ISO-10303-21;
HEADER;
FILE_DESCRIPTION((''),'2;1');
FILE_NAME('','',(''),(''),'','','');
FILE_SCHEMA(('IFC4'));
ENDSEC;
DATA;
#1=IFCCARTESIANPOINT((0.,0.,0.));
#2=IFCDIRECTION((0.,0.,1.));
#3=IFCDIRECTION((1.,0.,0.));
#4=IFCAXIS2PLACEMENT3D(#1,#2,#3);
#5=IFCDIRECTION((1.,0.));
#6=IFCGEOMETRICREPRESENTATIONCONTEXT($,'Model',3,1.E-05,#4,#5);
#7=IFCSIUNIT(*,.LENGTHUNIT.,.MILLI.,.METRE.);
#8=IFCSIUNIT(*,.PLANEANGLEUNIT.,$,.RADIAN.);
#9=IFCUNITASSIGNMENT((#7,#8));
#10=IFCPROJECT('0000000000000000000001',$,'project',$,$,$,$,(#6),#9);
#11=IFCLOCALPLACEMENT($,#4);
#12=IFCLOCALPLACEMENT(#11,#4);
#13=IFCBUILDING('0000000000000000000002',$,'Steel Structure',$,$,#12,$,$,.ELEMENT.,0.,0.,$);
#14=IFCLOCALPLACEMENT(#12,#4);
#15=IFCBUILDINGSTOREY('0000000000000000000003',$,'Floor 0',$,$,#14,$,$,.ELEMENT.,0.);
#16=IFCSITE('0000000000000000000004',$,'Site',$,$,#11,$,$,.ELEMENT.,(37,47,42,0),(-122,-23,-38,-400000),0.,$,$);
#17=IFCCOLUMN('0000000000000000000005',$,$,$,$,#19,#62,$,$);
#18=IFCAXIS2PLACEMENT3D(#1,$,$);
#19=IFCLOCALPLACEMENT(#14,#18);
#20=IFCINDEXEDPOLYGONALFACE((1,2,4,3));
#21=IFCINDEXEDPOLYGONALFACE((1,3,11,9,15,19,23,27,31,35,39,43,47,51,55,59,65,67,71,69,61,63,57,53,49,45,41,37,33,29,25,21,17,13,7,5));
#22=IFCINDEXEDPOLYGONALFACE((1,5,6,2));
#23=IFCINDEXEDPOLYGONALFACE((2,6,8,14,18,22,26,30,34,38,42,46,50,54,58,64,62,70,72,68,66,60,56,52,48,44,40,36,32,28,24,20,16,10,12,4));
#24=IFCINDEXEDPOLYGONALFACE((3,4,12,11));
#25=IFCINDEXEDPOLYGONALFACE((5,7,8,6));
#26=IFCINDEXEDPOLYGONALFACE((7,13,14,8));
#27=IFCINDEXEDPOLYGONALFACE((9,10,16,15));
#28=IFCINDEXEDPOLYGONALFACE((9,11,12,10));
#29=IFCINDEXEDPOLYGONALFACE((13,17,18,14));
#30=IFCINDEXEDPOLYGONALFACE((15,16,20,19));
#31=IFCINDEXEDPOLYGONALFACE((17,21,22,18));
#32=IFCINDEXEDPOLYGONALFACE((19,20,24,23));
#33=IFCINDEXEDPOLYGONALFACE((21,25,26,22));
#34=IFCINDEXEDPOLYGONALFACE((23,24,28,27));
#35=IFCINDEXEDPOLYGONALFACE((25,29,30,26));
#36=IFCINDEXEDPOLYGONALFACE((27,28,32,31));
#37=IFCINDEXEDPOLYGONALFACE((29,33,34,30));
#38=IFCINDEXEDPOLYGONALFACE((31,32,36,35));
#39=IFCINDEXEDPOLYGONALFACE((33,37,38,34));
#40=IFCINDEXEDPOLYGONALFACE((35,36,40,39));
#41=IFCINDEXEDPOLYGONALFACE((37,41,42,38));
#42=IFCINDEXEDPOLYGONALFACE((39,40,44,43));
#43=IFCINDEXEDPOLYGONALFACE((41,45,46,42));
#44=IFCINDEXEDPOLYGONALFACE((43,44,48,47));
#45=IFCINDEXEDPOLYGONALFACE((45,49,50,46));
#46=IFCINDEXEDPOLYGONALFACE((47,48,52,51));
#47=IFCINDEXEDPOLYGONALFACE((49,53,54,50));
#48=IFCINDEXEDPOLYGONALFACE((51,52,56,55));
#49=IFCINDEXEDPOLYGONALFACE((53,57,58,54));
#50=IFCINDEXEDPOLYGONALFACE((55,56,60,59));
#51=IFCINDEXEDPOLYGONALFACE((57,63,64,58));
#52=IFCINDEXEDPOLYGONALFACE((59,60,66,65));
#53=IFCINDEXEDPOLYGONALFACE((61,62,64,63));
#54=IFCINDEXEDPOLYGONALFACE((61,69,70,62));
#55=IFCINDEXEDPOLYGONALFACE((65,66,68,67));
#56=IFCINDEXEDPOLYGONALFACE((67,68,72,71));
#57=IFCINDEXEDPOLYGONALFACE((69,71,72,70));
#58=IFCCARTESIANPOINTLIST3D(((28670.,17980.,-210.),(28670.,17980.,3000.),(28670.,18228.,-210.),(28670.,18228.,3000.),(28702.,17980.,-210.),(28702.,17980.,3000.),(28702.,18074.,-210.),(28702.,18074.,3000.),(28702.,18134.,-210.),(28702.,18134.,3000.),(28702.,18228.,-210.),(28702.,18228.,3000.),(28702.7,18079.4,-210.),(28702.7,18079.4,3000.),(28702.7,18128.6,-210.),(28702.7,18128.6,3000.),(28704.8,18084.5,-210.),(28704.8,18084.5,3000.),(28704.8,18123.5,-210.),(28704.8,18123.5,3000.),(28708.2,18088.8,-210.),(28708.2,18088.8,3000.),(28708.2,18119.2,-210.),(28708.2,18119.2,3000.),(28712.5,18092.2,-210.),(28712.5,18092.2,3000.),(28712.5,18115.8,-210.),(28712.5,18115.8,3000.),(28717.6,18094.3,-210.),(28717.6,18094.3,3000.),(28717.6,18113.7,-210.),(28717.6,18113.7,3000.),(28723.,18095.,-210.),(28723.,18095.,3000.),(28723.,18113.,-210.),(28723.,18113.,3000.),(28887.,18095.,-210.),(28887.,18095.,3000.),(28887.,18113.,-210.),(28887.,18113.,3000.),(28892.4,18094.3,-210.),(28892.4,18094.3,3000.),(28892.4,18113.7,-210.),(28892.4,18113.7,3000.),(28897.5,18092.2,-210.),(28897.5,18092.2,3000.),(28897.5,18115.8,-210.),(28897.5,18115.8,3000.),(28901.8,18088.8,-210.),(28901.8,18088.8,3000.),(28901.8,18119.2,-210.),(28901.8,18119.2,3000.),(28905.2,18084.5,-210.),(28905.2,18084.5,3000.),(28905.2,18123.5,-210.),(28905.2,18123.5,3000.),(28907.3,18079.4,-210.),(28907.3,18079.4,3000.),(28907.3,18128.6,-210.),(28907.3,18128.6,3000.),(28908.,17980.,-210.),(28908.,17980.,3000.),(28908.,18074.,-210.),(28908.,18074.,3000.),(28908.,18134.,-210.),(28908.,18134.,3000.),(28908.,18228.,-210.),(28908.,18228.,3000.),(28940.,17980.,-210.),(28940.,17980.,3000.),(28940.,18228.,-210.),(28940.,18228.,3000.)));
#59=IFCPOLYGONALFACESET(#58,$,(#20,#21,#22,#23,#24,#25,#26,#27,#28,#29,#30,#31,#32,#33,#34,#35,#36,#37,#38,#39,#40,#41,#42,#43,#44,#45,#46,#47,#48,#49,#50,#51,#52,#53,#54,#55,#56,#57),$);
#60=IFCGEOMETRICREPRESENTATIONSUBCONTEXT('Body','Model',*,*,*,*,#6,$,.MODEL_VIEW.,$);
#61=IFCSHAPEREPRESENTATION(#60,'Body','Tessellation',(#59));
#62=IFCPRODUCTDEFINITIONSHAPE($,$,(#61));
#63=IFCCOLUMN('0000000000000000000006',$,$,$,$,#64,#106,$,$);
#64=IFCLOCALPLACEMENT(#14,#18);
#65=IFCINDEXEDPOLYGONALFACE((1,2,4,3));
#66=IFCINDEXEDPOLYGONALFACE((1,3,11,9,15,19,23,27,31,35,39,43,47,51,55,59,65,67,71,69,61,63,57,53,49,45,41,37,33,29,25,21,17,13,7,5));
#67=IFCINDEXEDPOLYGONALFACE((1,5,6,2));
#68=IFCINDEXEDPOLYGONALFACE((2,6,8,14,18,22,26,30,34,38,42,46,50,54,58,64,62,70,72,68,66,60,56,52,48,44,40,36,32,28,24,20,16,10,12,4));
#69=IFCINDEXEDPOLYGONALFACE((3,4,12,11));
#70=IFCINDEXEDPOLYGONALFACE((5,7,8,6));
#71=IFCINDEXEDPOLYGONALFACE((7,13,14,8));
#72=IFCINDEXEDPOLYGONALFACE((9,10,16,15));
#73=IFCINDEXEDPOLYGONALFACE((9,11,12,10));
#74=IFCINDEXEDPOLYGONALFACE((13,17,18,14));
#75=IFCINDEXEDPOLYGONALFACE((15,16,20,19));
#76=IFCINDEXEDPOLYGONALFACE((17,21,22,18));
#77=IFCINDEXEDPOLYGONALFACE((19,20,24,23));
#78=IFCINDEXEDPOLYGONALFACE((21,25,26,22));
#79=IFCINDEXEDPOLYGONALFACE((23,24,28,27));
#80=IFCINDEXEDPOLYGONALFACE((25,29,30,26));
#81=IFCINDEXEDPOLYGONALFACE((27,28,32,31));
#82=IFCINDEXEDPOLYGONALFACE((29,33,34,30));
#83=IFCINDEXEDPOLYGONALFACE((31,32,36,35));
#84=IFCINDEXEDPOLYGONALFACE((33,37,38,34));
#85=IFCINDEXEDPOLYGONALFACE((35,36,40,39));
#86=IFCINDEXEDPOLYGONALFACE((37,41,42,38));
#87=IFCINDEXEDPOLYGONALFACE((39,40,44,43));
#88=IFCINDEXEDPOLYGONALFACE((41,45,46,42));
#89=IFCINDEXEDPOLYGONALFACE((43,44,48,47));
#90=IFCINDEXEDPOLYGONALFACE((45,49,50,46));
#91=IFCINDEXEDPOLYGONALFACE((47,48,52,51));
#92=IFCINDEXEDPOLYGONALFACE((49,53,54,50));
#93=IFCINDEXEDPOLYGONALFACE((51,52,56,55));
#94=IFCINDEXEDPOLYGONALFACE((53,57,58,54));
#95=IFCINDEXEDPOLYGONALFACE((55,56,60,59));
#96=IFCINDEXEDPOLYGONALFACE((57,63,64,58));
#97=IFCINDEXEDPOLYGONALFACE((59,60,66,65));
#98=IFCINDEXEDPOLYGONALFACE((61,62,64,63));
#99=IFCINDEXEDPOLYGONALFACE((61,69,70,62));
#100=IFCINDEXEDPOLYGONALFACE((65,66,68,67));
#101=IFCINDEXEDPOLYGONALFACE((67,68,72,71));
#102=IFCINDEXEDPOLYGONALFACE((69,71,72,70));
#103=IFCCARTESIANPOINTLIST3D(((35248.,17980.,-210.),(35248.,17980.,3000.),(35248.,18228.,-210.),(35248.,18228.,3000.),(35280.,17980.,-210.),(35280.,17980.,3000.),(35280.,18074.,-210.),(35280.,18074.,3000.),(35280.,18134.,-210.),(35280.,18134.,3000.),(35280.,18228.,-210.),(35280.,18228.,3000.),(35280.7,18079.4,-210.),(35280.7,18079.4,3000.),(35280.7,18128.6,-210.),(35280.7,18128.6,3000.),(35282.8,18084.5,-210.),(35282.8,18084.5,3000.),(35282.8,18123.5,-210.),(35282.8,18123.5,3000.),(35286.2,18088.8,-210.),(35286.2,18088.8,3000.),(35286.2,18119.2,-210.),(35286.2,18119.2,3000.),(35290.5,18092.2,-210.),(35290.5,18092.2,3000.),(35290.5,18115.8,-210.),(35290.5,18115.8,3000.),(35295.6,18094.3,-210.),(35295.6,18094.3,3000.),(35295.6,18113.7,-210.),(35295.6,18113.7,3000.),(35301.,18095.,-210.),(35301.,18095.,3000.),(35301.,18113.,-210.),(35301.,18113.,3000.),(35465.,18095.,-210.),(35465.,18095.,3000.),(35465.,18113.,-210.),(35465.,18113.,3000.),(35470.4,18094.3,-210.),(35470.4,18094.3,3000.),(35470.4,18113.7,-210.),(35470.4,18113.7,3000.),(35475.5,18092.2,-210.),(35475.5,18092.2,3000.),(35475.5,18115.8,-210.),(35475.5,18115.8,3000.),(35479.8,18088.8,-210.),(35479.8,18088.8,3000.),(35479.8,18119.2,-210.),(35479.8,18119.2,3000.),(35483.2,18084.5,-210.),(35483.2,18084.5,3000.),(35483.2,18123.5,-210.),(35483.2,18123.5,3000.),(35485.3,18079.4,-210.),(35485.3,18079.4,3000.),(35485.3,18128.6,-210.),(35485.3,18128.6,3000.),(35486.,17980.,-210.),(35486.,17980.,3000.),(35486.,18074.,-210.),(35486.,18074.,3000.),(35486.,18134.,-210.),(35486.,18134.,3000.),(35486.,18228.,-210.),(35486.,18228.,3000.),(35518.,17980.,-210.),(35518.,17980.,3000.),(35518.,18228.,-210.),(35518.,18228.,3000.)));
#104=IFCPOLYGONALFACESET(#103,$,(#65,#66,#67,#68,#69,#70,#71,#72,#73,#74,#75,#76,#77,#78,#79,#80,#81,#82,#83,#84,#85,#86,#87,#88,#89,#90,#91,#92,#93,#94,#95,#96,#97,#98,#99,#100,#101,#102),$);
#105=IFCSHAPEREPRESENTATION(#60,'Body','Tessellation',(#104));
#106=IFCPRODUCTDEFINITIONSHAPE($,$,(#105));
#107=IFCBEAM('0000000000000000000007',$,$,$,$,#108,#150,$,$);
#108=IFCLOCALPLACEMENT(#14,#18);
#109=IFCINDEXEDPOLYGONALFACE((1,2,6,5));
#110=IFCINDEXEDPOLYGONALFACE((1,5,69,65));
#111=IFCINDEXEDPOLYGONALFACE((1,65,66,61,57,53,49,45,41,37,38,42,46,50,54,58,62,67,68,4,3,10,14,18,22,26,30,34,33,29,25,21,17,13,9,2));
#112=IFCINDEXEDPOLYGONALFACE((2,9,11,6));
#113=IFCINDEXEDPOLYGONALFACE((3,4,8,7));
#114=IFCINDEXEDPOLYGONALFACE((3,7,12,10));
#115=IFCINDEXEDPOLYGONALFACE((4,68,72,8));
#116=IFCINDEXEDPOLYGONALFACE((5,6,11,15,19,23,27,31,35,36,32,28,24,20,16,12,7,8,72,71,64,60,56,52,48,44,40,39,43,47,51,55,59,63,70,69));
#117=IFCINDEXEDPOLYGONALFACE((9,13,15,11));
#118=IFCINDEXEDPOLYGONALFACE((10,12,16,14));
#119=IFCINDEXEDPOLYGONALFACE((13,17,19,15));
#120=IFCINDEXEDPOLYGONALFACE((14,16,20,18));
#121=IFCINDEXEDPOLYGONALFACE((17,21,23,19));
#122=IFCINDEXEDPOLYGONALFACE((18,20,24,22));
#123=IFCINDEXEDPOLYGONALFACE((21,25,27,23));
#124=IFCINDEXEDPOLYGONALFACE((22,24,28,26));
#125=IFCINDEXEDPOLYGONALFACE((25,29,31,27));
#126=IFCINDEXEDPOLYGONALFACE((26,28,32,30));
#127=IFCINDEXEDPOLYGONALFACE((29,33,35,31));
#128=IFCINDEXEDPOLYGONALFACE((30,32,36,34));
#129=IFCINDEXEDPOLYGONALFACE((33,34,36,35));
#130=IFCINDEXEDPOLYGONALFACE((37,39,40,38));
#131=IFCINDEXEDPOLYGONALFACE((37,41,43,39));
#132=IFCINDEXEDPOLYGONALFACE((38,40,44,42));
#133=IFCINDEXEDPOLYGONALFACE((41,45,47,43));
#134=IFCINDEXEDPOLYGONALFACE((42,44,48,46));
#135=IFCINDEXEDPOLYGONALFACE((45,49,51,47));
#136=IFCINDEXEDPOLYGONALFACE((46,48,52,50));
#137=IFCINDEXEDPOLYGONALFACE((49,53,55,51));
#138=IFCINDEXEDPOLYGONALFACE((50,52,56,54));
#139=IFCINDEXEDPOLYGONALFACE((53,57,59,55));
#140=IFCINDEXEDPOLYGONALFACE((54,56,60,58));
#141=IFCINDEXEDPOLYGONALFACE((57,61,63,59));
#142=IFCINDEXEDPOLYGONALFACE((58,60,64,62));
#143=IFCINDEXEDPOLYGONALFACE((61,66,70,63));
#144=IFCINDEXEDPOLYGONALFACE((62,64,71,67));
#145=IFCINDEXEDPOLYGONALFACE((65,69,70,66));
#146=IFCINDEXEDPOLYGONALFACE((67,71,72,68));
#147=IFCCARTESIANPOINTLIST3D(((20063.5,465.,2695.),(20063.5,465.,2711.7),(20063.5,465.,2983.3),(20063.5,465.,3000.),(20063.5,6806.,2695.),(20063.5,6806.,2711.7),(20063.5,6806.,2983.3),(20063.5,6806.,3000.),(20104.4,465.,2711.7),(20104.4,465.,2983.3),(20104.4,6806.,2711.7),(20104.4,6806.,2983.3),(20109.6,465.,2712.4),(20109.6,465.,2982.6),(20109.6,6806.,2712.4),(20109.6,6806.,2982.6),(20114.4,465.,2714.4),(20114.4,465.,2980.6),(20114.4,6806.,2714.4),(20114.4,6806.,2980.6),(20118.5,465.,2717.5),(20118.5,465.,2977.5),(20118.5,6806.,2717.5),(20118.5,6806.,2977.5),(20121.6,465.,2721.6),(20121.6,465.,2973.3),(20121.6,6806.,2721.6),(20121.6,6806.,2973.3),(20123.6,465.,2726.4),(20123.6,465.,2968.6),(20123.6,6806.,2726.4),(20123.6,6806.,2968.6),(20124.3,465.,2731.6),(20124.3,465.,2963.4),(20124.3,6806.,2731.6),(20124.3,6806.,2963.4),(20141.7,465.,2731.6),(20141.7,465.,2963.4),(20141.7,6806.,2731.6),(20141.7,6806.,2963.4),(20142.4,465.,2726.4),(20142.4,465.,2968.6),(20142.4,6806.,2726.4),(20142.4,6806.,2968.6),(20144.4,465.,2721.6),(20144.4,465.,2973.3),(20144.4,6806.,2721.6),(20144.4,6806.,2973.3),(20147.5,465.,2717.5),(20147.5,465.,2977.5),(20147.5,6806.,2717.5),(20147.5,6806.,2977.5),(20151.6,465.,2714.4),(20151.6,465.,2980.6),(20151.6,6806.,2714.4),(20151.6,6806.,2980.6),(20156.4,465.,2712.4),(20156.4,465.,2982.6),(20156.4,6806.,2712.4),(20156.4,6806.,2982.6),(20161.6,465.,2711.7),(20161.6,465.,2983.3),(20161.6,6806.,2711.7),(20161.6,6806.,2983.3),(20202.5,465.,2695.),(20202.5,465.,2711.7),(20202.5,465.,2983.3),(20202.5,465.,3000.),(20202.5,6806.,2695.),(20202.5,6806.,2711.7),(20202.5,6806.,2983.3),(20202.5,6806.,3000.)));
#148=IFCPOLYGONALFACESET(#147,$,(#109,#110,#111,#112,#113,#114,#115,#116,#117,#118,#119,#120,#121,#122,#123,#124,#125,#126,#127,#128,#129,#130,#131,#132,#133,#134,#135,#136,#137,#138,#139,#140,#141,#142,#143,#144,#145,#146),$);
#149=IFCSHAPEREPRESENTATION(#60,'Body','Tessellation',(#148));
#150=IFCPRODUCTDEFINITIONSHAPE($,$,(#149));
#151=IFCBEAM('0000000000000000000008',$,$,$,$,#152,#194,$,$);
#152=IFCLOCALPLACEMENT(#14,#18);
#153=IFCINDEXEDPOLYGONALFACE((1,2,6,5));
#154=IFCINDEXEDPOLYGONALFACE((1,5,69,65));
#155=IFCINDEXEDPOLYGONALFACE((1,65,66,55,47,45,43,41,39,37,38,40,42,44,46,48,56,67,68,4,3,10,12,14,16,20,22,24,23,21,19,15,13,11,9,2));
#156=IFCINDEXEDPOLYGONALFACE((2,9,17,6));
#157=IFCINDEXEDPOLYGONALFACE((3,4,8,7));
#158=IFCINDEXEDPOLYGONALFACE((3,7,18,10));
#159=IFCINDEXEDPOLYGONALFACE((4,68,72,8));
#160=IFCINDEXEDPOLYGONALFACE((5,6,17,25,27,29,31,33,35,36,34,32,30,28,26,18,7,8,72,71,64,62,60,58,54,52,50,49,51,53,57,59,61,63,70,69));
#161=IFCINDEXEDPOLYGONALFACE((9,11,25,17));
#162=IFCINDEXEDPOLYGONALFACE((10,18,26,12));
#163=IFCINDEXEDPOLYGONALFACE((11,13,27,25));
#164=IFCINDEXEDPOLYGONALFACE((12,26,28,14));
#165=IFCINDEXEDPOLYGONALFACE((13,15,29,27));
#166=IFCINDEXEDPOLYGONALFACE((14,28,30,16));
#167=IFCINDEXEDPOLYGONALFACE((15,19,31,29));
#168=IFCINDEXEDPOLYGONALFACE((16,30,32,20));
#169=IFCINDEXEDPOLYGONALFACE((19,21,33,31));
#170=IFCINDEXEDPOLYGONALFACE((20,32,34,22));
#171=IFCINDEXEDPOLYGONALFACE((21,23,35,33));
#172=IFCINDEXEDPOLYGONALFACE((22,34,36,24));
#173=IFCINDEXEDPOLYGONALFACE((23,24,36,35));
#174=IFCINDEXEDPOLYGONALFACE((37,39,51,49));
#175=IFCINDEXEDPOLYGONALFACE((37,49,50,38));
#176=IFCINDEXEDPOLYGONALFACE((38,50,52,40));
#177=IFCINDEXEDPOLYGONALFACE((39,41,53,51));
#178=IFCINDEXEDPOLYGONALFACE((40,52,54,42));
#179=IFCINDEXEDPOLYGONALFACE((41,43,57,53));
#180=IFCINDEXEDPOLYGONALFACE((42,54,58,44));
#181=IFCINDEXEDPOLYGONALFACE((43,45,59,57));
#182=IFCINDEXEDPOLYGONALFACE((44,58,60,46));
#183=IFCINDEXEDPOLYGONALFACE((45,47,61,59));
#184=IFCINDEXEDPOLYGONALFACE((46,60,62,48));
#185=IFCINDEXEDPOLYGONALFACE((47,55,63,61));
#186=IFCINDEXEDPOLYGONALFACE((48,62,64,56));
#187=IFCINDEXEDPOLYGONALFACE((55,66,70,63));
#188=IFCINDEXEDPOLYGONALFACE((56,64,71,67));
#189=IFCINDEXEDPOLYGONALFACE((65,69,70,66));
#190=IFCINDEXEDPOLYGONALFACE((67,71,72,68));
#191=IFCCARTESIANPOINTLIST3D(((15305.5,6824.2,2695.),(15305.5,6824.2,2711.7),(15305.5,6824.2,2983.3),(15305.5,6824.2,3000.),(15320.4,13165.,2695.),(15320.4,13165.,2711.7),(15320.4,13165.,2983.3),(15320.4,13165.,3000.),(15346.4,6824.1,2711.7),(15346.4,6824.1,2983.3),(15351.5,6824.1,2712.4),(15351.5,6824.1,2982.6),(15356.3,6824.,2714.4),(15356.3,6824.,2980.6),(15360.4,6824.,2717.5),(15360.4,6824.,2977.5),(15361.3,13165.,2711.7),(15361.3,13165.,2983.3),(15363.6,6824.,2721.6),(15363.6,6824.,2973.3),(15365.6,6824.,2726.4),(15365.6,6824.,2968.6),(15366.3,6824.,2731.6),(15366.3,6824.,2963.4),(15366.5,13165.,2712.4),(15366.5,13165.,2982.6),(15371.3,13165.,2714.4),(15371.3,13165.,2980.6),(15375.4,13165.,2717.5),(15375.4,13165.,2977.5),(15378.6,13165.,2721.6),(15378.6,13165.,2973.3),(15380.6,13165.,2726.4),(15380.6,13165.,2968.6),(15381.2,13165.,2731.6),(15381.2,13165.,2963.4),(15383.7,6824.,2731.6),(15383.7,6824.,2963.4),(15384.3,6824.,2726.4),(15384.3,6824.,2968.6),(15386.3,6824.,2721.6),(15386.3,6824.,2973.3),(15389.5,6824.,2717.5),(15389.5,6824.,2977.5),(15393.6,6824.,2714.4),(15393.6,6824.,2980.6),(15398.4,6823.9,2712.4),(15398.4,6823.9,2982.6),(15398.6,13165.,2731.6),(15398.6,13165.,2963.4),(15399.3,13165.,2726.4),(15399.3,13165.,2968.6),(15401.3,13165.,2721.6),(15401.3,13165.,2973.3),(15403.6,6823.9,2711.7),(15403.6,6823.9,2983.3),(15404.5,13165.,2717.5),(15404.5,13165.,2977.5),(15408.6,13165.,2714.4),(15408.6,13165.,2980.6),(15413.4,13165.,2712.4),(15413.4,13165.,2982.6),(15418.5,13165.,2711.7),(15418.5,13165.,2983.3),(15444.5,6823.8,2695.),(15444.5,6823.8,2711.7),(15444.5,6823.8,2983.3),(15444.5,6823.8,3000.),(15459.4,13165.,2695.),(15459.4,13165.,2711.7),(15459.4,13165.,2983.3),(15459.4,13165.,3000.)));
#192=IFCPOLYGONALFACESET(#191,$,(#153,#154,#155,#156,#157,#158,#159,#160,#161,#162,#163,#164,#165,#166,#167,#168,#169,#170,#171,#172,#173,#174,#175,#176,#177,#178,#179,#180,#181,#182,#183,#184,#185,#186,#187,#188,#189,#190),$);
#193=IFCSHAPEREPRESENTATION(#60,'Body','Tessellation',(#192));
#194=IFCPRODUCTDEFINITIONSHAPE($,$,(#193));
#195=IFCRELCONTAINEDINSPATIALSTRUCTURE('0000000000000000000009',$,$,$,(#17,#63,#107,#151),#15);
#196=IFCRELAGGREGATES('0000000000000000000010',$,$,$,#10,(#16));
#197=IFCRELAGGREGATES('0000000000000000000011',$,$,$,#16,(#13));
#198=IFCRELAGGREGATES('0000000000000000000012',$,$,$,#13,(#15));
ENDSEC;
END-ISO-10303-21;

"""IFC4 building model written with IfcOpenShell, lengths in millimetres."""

from ifc_helpers import new_model, si_unit, direction, frame, origin_with_axes, origin_2d_with_axis, place, context, subcontext, project, spatial, polyline, i_section, extrude, clip, bounded_halfspace, element, save


model = new_model("IFC4")

# Units and contexts
model_context = context("Model", 3, precision=1e-05, world=origin_with_axes(), true_north=direction((1.0, 0.0)))
body_context = subcontext(model_context, "Body", "Model", "MODEL_VIEW")
ifc_project = project(units=[si_unit("LENGTHUNIT", "METRE", prefix="MILLI"), si_unit("PLANEANGLEUNIT", "RADIAN")], contexts=[model_context])

# Site, building, storey
site_placement = place(None, origin_with_axes())
site = spatial("IfcSite", under=ifc_project, at=site_placement, Name="Site", CompositionType="ELEMENT", RefLatitude=(37, 47, 42, 0), RefLongitude=(-122, -23, -38, -400000), RefElevation=0.0)
building_placement = place(site_placement, origin_with_axes())
building = spatial("IfcBuilding", under=site, at=building_placement, Name="Steel Structure", CompositionType="ELEMENT", ElevationOfRefHeight=0.0, ElevationOfTerrain=0.0)
storey_placement = place(building_placement, origin_with_axes())
storey = spatial("IfcBuildingStorey", under=building, at=storey_placement, Name="Floor 0", CompositionType="ELEMENT", Elevation=0.0)

# Columns
column_1_placement = place(storey_placement, frame((28805.0, 18104.0, -210.0), z_axis=(0.0, 0.0, 1.0), x_axis=(0.0, 1.0, 0.0)))
element("IfcColumn", 1, at=column_1_placement, inside=storey, context=body_context, shape_type="SweptSolid", body=[
    extrude(i_section(OverallWidth=248.0, OverallDepth=270.0, WebThickness=18.0, FlangeThickness=32.0, FilletRadius=21.0, at=origin_2d_with_axis()), origin_with_axes(), (0.0, 0.0, 1.0), 3210.0),
])
column_2_placement = place(storey_placement, frame((35383.0, 18104.0, -210.0), z_axis=(0.0, 0.0, 1.0), x_axis=(0.0, 1.0, 0.0)))
element("IfcColumn", 2, at=column_2_placement, inside=storey, context=body_context, shape_type="SweptSolid", body=[
    extrude(i_section(OverallWidth=248.0, OverallDepth=270.0, WebThickness=18.0, FlangeThickness=32.0, FilletRadius=21.0, at=origin_2d_with_axis()), origin_with_axes(), (0.0, 0.0, 1.0), 3210.0),
])

# Beams
beam_1_placement = place(storey_placement, frame((20133.0, 465.0, 2847.5), z_axis=(0.0, 1.0, 0.0), x_axis=(-1.0, 0.0, 0.0)))
element("IfcBeam", 3, at=beam_1_placement, inside=storey, context=body_context, shape_type="SweptSolid", body=[
    extrude(i_section(OverallWidth=139.0, OverallDepth=305.0, WebThickness=17.4, FlangeThickness=16.7, FilletRadius=19.9, at=origin_2d_with_axis()), origin_with_axes(), (0.0, 0.0, 1.0), 6341.0),
])
beam_2_placement = place(storey_placement, frame((15389.9, 13165.2, 2695.0), z_axis=(-0.002362, -0.999997, 0.0), x_axis=(0.999997, -0.002362, 0.0)))
element("IfcBeam", 4, at=beam_2_placement, inside=storey, context=body_context, shape_type="Clipping", body=[
    clip(extrude(i_section(OverallWidth=139.0, OverallDepth=305.0, WebThickness=17.4, FlangeThickness=16.7, FilletRadius=19.9, at=origin_2d_with_axis()), frame((0.0, 152.5, 0.0), z_axis=(0.0, 0.0, 1.0), x_axis=(1.0, 0.0, 0.0)), (0.0, 0.0, 1.0), 6341.2), bounded_halfspace(frame((-15389.9, -2695.0, 36.5), z_axis=(-0.002362, 0.0, -0.999997), x_axis=(-0.999997, 0.0, 0.002362)), False, frame((0.0, 152.5, 0.0), z_axis=(0.0, 0.0, 1.0), x_axis=(1.0, 0.0, 0.0)), polyline([(69.5, 152.5), (69.5, 135.8), (28.6, 135.8), (8.7, 115.9), (8.7, -115.9), (28.6, -135.8), (69.5, -135.8), (69.5, -152.5), (-69.5, -152.5), (-69.5, -135.8), (-28.6, -135.8), (-8.7, -115.9), (-8.7, 115.9), (-28.6, 135.8), (-69.5, 135.8), (-69.5, 152.5), (69.5, 152.5)]))),
])

save(model, "model.ifc")
